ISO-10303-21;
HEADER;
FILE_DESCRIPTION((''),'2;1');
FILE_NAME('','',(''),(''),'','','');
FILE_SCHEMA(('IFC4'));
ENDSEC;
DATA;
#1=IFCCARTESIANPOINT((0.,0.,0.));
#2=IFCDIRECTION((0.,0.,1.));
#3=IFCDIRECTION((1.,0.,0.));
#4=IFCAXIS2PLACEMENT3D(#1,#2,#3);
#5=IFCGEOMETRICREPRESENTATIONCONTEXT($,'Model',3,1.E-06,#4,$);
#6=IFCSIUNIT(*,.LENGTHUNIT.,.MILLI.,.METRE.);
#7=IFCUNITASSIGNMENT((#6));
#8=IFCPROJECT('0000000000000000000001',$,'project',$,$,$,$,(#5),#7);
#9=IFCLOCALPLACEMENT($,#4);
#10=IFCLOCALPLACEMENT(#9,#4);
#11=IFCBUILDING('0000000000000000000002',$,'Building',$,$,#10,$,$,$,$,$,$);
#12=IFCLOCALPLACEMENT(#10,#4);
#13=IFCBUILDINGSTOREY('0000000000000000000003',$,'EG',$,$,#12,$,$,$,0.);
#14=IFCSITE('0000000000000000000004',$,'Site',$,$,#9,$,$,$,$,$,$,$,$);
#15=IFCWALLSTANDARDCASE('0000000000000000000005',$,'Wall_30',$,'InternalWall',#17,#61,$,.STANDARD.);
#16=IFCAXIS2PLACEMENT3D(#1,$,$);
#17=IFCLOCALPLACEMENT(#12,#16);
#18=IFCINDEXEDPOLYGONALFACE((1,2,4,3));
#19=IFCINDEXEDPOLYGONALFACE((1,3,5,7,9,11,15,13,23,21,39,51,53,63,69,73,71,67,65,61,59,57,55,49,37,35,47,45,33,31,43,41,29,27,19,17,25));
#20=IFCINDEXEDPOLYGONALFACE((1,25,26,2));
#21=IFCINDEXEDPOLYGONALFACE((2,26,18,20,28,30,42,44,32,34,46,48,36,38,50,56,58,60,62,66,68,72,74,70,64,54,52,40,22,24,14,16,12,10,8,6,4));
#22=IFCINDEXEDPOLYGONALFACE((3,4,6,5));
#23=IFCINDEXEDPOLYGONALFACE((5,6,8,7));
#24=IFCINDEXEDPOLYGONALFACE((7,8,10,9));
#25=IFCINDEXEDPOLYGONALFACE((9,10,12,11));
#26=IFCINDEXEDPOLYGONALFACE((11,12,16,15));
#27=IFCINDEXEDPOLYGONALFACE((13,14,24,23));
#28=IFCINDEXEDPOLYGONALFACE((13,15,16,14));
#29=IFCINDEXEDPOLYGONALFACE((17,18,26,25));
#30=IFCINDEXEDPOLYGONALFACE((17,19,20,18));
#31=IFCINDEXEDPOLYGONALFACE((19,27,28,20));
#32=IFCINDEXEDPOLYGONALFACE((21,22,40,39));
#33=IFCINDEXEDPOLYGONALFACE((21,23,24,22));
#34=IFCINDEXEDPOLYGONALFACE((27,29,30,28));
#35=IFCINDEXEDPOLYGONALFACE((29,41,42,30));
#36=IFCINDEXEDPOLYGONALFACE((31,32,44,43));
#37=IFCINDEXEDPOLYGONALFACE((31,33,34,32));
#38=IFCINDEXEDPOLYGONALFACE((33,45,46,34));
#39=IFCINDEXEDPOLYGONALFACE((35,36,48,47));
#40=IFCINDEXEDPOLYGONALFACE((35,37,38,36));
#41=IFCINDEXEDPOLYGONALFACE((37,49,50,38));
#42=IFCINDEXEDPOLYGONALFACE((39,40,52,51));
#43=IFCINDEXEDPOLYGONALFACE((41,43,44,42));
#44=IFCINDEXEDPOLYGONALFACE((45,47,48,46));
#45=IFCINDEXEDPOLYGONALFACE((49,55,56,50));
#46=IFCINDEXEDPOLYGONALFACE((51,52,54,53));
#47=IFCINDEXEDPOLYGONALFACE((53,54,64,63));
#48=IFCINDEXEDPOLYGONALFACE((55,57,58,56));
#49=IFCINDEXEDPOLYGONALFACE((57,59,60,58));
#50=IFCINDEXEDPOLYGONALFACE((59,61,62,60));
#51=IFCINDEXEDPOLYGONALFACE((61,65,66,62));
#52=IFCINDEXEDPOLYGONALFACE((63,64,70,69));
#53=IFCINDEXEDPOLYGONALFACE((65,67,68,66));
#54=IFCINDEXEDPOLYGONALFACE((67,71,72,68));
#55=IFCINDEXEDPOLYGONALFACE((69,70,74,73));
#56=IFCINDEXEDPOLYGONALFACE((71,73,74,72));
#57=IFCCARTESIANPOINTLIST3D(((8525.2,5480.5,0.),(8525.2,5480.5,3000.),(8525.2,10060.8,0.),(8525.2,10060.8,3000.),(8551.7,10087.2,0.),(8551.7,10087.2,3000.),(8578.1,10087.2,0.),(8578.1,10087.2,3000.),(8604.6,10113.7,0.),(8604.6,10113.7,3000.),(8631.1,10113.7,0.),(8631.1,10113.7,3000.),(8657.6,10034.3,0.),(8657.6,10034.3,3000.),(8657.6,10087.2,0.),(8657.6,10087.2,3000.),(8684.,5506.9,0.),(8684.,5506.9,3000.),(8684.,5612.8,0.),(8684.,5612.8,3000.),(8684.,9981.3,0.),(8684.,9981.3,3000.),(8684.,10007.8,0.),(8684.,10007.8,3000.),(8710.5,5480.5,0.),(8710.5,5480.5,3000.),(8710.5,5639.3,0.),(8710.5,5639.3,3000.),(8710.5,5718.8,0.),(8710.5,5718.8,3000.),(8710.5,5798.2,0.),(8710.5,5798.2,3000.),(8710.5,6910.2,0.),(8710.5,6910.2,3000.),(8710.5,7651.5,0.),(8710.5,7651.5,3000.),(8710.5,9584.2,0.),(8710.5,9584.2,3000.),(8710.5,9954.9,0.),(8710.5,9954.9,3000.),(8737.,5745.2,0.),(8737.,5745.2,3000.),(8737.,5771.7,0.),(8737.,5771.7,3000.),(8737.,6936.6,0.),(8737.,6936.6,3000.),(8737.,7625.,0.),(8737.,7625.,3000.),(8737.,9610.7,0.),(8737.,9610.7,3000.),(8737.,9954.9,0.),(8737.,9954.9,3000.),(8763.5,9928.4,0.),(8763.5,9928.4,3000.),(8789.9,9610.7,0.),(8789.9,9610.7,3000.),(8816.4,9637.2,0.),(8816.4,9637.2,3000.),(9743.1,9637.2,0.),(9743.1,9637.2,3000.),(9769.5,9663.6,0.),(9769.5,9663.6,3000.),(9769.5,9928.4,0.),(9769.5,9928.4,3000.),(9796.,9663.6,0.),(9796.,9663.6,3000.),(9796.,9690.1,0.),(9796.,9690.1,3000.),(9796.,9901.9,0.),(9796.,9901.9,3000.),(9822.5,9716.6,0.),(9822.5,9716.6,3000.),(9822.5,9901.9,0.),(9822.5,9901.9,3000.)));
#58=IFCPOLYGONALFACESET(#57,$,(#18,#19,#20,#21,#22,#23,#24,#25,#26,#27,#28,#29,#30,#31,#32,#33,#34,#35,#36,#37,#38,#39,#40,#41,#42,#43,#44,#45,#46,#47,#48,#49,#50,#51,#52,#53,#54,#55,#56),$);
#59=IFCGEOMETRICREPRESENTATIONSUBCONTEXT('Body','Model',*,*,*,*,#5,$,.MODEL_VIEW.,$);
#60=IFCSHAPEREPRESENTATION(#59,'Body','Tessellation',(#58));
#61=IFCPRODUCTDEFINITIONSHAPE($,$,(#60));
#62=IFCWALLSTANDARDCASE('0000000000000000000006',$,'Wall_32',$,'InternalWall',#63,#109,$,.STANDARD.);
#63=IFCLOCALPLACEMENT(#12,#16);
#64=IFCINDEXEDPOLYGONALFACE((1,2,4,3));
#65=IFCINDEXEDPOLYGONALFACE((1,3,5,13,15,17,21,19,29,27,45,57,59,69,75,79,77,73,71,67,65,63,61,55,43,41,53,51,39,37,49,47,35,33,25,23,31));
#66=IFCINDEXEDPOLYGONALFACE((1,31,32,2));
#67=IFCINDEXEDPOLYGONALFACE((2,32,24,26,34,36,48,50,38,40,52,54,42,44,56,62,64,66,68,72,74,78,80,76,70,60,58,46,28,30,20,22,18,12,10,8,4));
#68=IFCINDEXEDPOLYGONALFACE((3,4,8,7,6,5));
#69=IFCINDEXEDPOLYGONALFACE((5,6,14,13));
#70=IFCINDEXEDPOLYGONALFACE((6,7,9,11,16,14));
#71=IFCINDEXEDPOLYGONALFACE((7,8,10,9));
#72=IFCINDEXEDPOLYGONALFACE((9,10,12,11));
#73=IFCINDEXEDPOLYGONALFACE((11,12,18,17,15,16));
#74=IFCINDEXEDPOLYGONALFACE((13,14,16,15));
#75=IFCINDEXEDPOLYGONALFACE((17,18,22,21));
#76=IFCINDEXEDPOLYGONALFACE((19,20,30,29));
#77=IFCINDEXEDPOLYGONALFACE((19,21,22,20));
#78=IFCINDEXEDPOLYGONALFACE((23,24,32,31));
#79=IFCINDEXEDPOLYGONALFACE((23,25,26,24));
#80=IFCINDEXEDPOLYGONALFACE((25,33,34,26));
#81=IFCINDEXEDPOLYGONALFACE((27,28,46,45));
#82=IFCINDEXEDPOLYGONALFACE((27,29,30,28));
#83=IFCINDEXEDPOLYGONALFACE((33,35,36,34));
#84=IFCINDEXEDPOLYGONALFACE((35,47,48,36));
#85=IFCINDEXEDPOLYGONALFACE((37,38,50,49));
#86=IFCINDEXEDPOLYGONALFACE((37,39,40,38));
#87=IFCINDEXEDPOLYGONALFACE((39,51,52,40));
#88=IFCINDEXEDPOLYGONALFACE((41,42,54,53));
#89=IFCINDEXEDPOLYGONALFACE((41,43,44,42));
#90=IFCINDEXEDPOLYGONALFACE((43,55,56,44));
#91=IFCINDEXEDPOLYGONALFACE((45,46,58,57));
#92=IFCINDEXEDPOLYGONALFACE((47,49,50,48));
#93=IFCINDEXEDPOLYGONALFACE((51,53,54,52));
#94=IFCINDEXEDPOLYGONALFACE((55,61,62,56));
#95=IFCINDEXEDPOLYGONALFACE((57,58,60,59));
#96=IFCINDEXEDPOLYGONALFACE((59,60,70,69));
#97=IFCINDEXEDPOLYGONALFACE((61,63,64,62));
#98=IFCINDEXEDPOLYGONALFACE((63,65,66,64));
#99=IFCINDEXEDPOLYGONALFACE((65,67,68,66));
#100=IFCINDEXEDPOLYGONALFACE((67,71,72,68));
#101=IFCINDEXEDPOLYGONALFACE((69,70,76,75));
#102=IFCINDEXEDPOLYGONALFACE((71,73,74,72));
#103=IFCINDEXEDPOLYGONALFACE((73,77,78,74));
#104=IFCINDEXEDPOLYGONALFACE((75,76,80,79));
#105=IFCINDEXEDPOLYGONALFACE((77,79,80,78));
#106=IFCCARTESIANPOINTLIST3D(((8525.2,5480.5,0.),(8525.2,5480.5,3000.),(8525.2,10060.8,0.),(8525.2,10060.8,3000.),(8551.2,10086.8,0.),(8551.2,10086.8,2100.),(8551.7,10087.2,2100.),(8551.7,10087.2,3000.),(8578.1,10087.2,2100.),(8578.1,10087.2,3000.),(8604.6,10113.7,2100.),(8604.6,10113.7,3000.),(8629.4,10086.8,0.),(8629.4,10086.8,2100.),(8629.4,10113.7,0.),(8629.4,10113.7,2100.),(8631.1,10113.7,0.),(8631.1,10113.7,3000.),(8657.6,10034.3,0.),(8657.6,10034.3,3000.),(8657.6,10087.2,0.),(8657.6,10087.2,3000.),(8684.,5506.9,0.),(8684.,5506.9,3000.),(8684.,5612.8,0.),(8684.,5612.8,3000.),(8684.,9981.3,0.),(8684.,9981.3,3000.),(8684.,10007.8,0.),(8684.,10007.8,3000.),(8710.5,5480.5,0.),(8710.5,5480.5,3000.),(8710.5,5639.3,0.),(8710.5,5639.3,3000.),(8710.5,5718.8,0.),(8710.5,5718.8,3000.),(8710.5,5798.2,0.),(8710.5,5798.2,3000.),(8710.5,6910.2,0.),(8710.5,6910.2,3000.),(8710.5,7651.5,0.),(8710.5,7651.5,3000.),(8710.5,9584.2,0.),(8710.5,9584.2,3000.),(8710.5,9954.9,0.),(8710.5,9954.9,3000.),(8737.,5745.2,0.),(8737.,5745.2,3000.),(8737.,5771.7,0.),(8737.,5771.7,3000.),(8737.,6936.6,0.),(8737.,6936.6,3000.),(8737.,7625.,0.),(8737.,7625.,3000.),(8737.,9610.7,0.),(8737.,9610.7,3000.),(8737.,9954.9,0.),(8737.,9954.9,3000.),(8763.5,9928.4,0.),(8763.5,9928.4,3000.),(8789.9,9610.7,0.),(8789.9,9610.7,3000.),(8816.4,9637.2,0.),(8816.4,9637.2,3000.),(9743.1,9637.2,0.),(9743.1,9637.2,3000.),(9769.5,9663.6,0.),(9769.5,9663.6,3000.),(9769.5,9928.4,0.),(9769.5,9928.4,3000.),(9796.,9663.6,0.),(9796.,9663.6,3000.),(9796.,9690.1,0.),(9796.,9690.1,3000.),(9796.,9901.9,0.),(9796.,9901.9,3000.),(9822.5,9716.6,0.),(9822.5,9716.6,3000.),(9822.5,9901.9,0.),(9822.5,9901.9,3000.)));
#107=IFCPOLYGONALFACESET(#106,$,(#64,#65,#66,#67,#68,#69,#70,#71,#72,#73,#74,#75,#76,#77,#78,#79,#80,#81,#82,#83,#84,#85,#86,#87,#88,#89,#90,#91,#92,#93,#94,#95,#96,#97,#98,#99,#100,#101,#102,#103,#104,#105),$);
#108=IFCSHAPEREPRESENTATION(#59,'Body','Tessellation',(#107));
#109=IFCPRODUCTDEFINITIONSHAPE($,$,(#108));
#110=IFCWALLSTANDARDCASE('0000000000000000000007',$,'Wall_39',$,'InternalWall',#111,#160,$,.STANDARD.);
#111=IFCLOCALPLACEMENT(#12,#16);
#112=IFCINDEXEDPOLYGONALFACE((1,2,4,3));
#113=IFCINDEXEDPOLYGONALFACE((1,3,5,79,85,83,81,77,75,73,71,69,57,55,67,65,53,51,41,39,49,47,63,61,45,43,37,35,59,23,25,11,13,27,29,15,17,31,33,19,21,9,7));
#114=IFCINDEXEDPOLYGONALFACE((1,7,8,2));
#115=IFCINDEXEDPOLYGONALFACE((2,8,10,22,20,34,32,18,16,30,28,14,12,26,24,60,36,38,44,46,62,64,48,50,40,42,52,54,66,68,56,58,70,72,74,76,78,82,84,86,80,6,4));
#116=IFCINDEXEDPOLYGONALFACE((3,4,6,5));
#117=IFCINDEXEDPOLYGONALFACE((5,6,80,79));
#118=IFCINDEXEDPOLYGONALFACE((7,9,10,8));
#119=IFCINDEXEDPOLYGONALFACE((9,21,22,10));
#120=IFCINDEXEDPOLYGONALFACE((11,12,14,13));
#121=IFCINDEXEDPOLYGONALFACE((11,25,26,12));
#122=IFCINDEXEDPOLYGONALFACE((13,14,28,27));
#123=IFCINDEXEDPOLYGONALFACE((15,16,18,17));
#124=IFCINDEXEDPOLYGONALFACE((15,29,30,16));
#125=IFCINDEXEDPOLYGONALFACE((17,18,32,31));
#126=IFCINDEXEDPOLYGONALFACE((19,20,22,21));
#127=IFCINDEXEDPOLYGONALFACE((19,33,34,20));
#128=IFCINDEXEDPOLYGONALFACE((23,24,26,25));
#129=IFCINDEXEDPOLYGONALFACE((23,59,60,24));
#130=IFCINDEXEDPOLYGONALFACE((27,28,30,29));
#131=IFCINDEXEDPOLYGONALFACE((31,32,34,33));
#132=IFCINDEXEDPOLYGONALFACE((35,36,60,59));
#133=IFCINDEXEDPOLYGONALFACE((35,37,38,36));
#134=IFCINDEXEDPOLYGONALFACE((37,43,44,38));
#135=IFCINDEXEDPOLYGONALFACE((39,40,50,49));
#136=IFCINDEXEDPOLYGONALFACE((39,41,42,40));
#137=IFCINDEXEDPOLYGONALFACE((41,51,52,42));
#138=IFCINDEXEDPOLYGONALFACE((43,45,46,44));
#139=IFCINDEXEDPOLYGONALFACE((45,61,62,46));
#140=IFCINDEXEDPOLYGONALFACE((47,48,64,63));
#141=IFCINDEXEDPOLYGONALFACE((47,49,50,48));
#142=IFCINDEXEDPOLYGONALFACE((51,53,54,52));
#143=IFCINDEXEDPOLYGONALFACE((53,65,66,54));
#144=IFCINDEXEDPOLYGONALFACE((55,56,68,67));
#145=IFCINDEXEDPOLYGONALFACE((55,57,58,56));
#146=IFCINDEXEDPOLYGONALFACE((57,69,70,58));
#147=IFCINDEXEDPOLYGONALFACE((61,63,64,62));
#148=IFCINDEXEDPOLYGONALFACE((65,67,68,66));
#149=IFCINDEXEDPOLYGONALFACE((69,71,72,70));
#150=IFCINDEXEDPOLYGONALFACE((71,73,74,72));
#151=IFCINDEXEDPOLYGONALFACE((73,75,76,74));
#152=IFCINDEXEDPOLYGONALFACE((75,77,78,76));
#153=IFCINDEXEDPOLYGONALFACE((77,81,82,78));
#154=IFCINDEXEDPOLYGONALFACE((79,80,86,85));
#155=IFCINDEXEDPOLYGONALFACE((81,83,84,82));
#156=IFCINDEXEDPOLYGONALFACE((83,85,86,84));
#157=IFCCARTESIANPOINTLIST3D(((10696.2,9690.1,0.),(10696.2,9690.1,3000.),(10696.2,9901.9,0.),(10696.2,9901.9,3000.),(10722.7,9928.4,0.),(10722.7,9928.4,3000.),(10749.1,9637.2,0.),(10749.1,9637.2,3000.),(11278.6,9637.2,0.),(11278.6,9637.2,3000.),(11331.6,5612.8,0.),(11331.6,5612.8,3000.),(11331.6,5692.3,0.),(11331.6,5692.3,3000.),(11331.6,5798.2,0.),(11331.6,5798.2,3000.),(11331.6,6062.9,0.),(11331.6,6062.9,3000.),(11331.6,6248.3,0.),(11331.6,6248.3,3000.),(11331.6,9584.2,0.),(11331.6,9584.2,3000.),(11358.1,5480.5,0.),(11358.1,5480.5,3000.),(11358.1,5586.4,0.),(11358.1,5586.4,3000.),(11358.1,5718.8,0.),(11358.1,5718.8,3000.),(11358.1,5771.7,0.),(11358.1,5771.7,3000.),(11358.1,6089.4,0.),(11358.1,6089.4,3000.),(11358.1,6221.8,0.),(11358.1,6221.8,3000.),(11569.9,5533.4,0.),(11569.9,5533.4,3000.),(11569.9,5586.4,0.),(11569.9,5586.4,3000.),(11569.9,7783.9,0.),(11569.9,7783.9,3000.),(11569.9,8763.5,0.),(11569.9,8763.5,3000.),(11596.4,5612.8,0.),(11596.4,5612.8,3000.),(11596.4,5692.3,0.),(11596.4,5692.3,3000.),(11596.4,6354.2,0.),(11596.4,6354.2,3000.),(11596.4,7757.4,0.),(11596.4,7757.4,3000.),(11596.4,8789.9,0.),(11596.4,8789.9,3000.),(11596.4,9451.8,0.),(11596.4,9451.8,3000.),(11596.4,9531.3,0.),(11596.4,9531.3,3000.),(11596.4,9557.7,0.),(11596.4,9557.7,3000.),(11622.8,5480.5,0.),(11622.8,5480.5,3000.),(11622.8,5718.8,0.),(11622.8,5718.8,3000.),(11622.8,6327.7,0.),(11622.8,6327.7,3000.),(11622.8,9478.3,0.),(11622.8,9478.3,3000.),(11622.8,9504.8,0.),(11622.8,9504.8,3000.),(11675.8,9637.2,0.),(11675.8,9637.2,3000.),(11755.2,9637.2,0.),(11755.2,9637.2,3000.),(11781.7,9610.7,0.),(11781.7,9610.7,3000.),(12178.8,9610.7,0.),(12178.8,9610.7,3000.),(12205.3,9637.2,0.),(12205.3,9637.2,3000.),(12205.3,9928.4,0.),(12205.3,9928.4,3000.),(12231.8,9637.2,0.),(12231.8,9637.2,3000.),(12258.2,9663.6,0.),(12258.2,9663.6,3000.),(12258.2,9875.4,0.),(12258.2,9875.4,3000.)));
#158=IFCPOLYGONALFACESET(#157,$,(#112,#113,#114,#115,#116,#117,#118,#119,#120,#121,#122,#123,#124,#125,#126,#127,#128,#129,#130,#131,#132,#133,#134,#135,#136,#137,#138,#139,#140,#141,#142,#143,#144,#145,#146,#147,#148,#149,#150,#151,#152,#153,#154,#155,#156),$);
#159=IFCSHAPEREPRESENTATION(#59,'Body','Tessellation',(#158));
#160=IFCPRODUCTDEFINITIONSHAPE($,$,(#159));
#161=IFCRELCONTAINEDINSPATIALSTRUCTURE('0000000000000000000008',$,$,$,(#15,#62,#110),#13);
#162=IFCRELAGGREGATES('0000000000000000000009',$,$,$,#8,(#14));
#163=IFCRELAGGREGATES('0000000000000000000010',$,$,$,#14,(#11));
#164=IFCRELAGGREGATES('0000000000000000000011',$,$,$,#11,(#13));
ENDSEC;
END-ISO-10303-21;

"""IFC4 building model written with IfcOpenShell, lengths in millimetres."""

from ifc_helpers import new_model, si_unit, frame, origin_with_axes, place, context, subcontext, project, spatial, polyline, rectangle, outline, extrude, element, save


model = new_model("IFC4")

# Units and contexts
model_context = context("Model", 3, precision=1e-06, world=origin_with_axes())
body_context = subcontext(model_context, "Body", "Model", "MODEL_VIEW")
ifc_project = project(units=[si_unit("LENGTHUNIT", "METRE", prefix="MILLI")], contexts=[model_context])

# Site, building, storey
site_placement = place(None, origin_with_axes())
site = spatial("IfcSite", under=ifc_project, at=site_placement, Name="Site")
building_placement = place(site_placement, origin_with_axes())
building = spatial("IfcBuilding", under=site, at=building_placement, Name="Building")
storey_placement = place(building_placement, origin_with_axes())
storey = spatial("IfcBuildingStorey", under=building, at=storey_placement, Name="EG", Elevation=0.0)

# Wall
for number, where, z_axis, x_axis, name in (
    (1, (0.0, 0.0, 0.0), (0.0, 0.0, 1.0), (1.0, 0.0, 0.0), "Wall_30"),
):
    element("IfcWallStandardCase", number, at=place(storey_placement, frame(where, z_axis=z_axis, x_axis=x_axis)), inside=storey, Name=name, ObjectType="InternalWall", PredefinedType="STANDARD", context=body_context, shape_type="SweptSolid", body=[
        extrude(outline(polyline([(8525.2, 5480.5, 0.0), (8525.2, 10060.8, 0.0), (8551.7, 10087.2, 0.0), (8578.1, 10087.2, 0.0), (8604.6, 10113.7, 0.0), (8631.1, 10113.7, 0.0), (8657.6, 10087.2, 0.0), (8657.6, 10034.3, 0.0), (8684.0, 10007.8, 0.0), (8684.0, 9981.3, 0.0), (8710.5, 9954.9, 0.0), (8737.0, 9954.9, 0.0), (8763.5, 9928.4, 0.0), (9769.5, 9928.4, 0.0), (9796.0, 9901.9, 0.0), (9822.5, 9901.9, 0.0), (9822.5, 9716.6, 0.0), (9796.0, 9690.1, 0.0), (9796.0, 9663.6, 0.0), (9769.5, 9663.6, 0.0), (9743.1, 9637.2, 0.0), (8816.4, 9637.2, 0.0), (8789.9, 9610.7, 0.0), (8737.0, 9610.7, 0.0), (8710.5, 9584.2, 0.0), (8710.5, 7651.5, 0.0), (8737.0, 7625.0, 0.0), (8737.0, 6936.6, 0.0), (8710.5, 6910.2, 0.0), (8710.5, 5798.2, 0.0), (8737.0, 5771.7, 0.0), (8737.0, 5745.2, 0.0), (8710.5, 5718.8, 0.0), (8710.5, 5639.3, 0.0), (8684.0, 5612.8, 0.0), (8684.0, 5506.9, 0.0), (8710.5, 5480.5, 0.0), (8525.2, 5480.5, 0.0)])), origin_with_axes(), (0.0, 0.0, 1.0), 3000.0),
    ])

# Wall, opening
wall_1_placement = place(storey_placement, origin_with_axes())
wall_1 = element("IfcWallStandardCase", 2, at=wall_1_placement, inside=storey, Name="Wall_32", ObjectType="InternalWall", PredefinedType="STANDARD", context=body_context, shape_type="SweptSolid", body=[
    extrude(outline(polyline([(8525.2, 5480.5, 0.0), (8525.2, 10060.8, 0.0), (8551.7, 10087.2, 0.0), (8578.1, 10087.2, 0.0), (8604.6, 10113.7, 0.0), (8631.1, 10113.7, 0.0), (8657.6, 10087.2, 0.0), (8657.6, 10034.3, 0.0), (8684.0, 10007.8, 0.0), (8684.0, 9981.3, 0.0), (8710.5, 9954.9, 0.0), (8737.0, 9954.9, 0.0), (8763.5, 9928.4, 0.0), (9769.5, 9928.4, 0.0), (9796.0, 9901.9, 0.0), (9822.5, 9901.9, 0.0), (9822.5, 9716.6, 0.0), (9796.0, 9690.1, 0.0), (9796.0, 9663.6, 0.0), (9769.5, 9663.6, 0.0), (9743.1, 9637.2, 0.0), (8816.4, 9637.2, 0.0), (8789.9, 9610.7, 0.0), (8737.0, 9610.7, 0.0), (8710.5, 9584.2, 0.0), (8710.5, 7651.5, 0.0), (8737.0, 7625.0, 0.0), (8737.0, 6936.6, 0.0), (8710.5, 6910.2, 0.0), (8710.5, 5798.2, 0.0), (8737.0, 5771.7, 0.0), (8737.0, 5745.2, 0.0), (8710.5, 5718.8, 0.0), (8710.5, 5639.3, 0.0), (8684.0, 5612.8, 0.0), (8684.0, 5506.9, 0.0), (8710.5, 5480.5, 0.0), (8525.2, 5480.5, 0.0)])), origin_with_axes(), (0.0, 0.0, 1.0), 3000.0),
])
opening_1_placement = place(wall_1_placement, origin_with_axes())
element("IfcOpeningElement", 3, at=opening_1_placement, inside=storey, cuts=wall_1, context=body_context, shape_type="SweptSolid", body=[
    extrude(rectangle(XDim=1344.8, YDim=240.0), frame((8509.4, 10759.2, 0.0), z_axis=(0.0, 0.0, 1.0), x_axis=(0.0, 1.0, 0.0)), (0.0, 0.0, 1.0), 2100.0),
])

# Wall
wall_2_placement = place(storey_placement, origin_with_axes())
element("IfcWallStandardCase", 4, at=wall_2_placement, inside=storey, Name="Wall_39", ObjectType="InternalWall", PredefinedType="STANDARD", context=body_context, shape_type="SweptSolid", body=[
    extrude(outline(polyline([(11358.1, 5480.5, 0.0), (11358.1, 5586.4, 0.0), (11331.6, 5612.8, 0.0), (11331.6, 5692.3, 0.0), (11358.1, 5718.8, 0.0), (11358.1, 5771.7, 0.0), (11331.6, 5798.2, 0.0), (11331.6, 6062.9, 0.0), (11358.1, 6089.4, 0.0), (11358.1, 6221.8, 0.0), (11331.6, 6248.3, 0.0), (11331.6, 9584.2, 0.0), (11278.6, 9637.2, 0.0), (10749.1, 9637.2, 0.0), (10696.2, 9690.1, 0.0), (10696.2, 9901.9, 0.0), (10722.7, 9928.4, 0.0), (12205.3, 9928.4, 0.0), (12258.2, 9875.4, 0.0), (12258.2, 9663.6, 0.0), (12231.8, 9637.2, 0.0), (12205.3, 9637.2, 0.0), (12178.8, 9610.7, 0.0), (11781.7, 9610.7, 0.0), (11755.2, 9637.2, 0.0), (11675.8, 9637.2, 0.0), (11596.4, 9557.7, 0.0), (11596.4, 9531.3, 0.0), (11622.8, 9504.8, 0.0), (11622.8, 9478.3, 0.0), (11596.4, 9451.8, 0.0), (11596.4, 8789.9, 0.0), (11569.9, 8763.5, 0.0), (11569.9, 7783.9, 0.0), (11596.4, 7757.4, 0.0), (11596.4, 6354.2, 0.0), (11622.8, 6327.7, 0.0), (11622.8, 5718.8, 0.0), (11596.4, 5692.3, 0.0), (11596.4, 5612.8, 0.0), (11569.9, 5586.4, 0.0), (11569.9, 5533.4, 0.0), (11622.8, 5480.5, 0.0), (11358.1, 5480.5, 0.0)])), origin_with_axes(), (0.0, 0.0, 1.0), 3000.0),
])

save(model, "model.ifc")
